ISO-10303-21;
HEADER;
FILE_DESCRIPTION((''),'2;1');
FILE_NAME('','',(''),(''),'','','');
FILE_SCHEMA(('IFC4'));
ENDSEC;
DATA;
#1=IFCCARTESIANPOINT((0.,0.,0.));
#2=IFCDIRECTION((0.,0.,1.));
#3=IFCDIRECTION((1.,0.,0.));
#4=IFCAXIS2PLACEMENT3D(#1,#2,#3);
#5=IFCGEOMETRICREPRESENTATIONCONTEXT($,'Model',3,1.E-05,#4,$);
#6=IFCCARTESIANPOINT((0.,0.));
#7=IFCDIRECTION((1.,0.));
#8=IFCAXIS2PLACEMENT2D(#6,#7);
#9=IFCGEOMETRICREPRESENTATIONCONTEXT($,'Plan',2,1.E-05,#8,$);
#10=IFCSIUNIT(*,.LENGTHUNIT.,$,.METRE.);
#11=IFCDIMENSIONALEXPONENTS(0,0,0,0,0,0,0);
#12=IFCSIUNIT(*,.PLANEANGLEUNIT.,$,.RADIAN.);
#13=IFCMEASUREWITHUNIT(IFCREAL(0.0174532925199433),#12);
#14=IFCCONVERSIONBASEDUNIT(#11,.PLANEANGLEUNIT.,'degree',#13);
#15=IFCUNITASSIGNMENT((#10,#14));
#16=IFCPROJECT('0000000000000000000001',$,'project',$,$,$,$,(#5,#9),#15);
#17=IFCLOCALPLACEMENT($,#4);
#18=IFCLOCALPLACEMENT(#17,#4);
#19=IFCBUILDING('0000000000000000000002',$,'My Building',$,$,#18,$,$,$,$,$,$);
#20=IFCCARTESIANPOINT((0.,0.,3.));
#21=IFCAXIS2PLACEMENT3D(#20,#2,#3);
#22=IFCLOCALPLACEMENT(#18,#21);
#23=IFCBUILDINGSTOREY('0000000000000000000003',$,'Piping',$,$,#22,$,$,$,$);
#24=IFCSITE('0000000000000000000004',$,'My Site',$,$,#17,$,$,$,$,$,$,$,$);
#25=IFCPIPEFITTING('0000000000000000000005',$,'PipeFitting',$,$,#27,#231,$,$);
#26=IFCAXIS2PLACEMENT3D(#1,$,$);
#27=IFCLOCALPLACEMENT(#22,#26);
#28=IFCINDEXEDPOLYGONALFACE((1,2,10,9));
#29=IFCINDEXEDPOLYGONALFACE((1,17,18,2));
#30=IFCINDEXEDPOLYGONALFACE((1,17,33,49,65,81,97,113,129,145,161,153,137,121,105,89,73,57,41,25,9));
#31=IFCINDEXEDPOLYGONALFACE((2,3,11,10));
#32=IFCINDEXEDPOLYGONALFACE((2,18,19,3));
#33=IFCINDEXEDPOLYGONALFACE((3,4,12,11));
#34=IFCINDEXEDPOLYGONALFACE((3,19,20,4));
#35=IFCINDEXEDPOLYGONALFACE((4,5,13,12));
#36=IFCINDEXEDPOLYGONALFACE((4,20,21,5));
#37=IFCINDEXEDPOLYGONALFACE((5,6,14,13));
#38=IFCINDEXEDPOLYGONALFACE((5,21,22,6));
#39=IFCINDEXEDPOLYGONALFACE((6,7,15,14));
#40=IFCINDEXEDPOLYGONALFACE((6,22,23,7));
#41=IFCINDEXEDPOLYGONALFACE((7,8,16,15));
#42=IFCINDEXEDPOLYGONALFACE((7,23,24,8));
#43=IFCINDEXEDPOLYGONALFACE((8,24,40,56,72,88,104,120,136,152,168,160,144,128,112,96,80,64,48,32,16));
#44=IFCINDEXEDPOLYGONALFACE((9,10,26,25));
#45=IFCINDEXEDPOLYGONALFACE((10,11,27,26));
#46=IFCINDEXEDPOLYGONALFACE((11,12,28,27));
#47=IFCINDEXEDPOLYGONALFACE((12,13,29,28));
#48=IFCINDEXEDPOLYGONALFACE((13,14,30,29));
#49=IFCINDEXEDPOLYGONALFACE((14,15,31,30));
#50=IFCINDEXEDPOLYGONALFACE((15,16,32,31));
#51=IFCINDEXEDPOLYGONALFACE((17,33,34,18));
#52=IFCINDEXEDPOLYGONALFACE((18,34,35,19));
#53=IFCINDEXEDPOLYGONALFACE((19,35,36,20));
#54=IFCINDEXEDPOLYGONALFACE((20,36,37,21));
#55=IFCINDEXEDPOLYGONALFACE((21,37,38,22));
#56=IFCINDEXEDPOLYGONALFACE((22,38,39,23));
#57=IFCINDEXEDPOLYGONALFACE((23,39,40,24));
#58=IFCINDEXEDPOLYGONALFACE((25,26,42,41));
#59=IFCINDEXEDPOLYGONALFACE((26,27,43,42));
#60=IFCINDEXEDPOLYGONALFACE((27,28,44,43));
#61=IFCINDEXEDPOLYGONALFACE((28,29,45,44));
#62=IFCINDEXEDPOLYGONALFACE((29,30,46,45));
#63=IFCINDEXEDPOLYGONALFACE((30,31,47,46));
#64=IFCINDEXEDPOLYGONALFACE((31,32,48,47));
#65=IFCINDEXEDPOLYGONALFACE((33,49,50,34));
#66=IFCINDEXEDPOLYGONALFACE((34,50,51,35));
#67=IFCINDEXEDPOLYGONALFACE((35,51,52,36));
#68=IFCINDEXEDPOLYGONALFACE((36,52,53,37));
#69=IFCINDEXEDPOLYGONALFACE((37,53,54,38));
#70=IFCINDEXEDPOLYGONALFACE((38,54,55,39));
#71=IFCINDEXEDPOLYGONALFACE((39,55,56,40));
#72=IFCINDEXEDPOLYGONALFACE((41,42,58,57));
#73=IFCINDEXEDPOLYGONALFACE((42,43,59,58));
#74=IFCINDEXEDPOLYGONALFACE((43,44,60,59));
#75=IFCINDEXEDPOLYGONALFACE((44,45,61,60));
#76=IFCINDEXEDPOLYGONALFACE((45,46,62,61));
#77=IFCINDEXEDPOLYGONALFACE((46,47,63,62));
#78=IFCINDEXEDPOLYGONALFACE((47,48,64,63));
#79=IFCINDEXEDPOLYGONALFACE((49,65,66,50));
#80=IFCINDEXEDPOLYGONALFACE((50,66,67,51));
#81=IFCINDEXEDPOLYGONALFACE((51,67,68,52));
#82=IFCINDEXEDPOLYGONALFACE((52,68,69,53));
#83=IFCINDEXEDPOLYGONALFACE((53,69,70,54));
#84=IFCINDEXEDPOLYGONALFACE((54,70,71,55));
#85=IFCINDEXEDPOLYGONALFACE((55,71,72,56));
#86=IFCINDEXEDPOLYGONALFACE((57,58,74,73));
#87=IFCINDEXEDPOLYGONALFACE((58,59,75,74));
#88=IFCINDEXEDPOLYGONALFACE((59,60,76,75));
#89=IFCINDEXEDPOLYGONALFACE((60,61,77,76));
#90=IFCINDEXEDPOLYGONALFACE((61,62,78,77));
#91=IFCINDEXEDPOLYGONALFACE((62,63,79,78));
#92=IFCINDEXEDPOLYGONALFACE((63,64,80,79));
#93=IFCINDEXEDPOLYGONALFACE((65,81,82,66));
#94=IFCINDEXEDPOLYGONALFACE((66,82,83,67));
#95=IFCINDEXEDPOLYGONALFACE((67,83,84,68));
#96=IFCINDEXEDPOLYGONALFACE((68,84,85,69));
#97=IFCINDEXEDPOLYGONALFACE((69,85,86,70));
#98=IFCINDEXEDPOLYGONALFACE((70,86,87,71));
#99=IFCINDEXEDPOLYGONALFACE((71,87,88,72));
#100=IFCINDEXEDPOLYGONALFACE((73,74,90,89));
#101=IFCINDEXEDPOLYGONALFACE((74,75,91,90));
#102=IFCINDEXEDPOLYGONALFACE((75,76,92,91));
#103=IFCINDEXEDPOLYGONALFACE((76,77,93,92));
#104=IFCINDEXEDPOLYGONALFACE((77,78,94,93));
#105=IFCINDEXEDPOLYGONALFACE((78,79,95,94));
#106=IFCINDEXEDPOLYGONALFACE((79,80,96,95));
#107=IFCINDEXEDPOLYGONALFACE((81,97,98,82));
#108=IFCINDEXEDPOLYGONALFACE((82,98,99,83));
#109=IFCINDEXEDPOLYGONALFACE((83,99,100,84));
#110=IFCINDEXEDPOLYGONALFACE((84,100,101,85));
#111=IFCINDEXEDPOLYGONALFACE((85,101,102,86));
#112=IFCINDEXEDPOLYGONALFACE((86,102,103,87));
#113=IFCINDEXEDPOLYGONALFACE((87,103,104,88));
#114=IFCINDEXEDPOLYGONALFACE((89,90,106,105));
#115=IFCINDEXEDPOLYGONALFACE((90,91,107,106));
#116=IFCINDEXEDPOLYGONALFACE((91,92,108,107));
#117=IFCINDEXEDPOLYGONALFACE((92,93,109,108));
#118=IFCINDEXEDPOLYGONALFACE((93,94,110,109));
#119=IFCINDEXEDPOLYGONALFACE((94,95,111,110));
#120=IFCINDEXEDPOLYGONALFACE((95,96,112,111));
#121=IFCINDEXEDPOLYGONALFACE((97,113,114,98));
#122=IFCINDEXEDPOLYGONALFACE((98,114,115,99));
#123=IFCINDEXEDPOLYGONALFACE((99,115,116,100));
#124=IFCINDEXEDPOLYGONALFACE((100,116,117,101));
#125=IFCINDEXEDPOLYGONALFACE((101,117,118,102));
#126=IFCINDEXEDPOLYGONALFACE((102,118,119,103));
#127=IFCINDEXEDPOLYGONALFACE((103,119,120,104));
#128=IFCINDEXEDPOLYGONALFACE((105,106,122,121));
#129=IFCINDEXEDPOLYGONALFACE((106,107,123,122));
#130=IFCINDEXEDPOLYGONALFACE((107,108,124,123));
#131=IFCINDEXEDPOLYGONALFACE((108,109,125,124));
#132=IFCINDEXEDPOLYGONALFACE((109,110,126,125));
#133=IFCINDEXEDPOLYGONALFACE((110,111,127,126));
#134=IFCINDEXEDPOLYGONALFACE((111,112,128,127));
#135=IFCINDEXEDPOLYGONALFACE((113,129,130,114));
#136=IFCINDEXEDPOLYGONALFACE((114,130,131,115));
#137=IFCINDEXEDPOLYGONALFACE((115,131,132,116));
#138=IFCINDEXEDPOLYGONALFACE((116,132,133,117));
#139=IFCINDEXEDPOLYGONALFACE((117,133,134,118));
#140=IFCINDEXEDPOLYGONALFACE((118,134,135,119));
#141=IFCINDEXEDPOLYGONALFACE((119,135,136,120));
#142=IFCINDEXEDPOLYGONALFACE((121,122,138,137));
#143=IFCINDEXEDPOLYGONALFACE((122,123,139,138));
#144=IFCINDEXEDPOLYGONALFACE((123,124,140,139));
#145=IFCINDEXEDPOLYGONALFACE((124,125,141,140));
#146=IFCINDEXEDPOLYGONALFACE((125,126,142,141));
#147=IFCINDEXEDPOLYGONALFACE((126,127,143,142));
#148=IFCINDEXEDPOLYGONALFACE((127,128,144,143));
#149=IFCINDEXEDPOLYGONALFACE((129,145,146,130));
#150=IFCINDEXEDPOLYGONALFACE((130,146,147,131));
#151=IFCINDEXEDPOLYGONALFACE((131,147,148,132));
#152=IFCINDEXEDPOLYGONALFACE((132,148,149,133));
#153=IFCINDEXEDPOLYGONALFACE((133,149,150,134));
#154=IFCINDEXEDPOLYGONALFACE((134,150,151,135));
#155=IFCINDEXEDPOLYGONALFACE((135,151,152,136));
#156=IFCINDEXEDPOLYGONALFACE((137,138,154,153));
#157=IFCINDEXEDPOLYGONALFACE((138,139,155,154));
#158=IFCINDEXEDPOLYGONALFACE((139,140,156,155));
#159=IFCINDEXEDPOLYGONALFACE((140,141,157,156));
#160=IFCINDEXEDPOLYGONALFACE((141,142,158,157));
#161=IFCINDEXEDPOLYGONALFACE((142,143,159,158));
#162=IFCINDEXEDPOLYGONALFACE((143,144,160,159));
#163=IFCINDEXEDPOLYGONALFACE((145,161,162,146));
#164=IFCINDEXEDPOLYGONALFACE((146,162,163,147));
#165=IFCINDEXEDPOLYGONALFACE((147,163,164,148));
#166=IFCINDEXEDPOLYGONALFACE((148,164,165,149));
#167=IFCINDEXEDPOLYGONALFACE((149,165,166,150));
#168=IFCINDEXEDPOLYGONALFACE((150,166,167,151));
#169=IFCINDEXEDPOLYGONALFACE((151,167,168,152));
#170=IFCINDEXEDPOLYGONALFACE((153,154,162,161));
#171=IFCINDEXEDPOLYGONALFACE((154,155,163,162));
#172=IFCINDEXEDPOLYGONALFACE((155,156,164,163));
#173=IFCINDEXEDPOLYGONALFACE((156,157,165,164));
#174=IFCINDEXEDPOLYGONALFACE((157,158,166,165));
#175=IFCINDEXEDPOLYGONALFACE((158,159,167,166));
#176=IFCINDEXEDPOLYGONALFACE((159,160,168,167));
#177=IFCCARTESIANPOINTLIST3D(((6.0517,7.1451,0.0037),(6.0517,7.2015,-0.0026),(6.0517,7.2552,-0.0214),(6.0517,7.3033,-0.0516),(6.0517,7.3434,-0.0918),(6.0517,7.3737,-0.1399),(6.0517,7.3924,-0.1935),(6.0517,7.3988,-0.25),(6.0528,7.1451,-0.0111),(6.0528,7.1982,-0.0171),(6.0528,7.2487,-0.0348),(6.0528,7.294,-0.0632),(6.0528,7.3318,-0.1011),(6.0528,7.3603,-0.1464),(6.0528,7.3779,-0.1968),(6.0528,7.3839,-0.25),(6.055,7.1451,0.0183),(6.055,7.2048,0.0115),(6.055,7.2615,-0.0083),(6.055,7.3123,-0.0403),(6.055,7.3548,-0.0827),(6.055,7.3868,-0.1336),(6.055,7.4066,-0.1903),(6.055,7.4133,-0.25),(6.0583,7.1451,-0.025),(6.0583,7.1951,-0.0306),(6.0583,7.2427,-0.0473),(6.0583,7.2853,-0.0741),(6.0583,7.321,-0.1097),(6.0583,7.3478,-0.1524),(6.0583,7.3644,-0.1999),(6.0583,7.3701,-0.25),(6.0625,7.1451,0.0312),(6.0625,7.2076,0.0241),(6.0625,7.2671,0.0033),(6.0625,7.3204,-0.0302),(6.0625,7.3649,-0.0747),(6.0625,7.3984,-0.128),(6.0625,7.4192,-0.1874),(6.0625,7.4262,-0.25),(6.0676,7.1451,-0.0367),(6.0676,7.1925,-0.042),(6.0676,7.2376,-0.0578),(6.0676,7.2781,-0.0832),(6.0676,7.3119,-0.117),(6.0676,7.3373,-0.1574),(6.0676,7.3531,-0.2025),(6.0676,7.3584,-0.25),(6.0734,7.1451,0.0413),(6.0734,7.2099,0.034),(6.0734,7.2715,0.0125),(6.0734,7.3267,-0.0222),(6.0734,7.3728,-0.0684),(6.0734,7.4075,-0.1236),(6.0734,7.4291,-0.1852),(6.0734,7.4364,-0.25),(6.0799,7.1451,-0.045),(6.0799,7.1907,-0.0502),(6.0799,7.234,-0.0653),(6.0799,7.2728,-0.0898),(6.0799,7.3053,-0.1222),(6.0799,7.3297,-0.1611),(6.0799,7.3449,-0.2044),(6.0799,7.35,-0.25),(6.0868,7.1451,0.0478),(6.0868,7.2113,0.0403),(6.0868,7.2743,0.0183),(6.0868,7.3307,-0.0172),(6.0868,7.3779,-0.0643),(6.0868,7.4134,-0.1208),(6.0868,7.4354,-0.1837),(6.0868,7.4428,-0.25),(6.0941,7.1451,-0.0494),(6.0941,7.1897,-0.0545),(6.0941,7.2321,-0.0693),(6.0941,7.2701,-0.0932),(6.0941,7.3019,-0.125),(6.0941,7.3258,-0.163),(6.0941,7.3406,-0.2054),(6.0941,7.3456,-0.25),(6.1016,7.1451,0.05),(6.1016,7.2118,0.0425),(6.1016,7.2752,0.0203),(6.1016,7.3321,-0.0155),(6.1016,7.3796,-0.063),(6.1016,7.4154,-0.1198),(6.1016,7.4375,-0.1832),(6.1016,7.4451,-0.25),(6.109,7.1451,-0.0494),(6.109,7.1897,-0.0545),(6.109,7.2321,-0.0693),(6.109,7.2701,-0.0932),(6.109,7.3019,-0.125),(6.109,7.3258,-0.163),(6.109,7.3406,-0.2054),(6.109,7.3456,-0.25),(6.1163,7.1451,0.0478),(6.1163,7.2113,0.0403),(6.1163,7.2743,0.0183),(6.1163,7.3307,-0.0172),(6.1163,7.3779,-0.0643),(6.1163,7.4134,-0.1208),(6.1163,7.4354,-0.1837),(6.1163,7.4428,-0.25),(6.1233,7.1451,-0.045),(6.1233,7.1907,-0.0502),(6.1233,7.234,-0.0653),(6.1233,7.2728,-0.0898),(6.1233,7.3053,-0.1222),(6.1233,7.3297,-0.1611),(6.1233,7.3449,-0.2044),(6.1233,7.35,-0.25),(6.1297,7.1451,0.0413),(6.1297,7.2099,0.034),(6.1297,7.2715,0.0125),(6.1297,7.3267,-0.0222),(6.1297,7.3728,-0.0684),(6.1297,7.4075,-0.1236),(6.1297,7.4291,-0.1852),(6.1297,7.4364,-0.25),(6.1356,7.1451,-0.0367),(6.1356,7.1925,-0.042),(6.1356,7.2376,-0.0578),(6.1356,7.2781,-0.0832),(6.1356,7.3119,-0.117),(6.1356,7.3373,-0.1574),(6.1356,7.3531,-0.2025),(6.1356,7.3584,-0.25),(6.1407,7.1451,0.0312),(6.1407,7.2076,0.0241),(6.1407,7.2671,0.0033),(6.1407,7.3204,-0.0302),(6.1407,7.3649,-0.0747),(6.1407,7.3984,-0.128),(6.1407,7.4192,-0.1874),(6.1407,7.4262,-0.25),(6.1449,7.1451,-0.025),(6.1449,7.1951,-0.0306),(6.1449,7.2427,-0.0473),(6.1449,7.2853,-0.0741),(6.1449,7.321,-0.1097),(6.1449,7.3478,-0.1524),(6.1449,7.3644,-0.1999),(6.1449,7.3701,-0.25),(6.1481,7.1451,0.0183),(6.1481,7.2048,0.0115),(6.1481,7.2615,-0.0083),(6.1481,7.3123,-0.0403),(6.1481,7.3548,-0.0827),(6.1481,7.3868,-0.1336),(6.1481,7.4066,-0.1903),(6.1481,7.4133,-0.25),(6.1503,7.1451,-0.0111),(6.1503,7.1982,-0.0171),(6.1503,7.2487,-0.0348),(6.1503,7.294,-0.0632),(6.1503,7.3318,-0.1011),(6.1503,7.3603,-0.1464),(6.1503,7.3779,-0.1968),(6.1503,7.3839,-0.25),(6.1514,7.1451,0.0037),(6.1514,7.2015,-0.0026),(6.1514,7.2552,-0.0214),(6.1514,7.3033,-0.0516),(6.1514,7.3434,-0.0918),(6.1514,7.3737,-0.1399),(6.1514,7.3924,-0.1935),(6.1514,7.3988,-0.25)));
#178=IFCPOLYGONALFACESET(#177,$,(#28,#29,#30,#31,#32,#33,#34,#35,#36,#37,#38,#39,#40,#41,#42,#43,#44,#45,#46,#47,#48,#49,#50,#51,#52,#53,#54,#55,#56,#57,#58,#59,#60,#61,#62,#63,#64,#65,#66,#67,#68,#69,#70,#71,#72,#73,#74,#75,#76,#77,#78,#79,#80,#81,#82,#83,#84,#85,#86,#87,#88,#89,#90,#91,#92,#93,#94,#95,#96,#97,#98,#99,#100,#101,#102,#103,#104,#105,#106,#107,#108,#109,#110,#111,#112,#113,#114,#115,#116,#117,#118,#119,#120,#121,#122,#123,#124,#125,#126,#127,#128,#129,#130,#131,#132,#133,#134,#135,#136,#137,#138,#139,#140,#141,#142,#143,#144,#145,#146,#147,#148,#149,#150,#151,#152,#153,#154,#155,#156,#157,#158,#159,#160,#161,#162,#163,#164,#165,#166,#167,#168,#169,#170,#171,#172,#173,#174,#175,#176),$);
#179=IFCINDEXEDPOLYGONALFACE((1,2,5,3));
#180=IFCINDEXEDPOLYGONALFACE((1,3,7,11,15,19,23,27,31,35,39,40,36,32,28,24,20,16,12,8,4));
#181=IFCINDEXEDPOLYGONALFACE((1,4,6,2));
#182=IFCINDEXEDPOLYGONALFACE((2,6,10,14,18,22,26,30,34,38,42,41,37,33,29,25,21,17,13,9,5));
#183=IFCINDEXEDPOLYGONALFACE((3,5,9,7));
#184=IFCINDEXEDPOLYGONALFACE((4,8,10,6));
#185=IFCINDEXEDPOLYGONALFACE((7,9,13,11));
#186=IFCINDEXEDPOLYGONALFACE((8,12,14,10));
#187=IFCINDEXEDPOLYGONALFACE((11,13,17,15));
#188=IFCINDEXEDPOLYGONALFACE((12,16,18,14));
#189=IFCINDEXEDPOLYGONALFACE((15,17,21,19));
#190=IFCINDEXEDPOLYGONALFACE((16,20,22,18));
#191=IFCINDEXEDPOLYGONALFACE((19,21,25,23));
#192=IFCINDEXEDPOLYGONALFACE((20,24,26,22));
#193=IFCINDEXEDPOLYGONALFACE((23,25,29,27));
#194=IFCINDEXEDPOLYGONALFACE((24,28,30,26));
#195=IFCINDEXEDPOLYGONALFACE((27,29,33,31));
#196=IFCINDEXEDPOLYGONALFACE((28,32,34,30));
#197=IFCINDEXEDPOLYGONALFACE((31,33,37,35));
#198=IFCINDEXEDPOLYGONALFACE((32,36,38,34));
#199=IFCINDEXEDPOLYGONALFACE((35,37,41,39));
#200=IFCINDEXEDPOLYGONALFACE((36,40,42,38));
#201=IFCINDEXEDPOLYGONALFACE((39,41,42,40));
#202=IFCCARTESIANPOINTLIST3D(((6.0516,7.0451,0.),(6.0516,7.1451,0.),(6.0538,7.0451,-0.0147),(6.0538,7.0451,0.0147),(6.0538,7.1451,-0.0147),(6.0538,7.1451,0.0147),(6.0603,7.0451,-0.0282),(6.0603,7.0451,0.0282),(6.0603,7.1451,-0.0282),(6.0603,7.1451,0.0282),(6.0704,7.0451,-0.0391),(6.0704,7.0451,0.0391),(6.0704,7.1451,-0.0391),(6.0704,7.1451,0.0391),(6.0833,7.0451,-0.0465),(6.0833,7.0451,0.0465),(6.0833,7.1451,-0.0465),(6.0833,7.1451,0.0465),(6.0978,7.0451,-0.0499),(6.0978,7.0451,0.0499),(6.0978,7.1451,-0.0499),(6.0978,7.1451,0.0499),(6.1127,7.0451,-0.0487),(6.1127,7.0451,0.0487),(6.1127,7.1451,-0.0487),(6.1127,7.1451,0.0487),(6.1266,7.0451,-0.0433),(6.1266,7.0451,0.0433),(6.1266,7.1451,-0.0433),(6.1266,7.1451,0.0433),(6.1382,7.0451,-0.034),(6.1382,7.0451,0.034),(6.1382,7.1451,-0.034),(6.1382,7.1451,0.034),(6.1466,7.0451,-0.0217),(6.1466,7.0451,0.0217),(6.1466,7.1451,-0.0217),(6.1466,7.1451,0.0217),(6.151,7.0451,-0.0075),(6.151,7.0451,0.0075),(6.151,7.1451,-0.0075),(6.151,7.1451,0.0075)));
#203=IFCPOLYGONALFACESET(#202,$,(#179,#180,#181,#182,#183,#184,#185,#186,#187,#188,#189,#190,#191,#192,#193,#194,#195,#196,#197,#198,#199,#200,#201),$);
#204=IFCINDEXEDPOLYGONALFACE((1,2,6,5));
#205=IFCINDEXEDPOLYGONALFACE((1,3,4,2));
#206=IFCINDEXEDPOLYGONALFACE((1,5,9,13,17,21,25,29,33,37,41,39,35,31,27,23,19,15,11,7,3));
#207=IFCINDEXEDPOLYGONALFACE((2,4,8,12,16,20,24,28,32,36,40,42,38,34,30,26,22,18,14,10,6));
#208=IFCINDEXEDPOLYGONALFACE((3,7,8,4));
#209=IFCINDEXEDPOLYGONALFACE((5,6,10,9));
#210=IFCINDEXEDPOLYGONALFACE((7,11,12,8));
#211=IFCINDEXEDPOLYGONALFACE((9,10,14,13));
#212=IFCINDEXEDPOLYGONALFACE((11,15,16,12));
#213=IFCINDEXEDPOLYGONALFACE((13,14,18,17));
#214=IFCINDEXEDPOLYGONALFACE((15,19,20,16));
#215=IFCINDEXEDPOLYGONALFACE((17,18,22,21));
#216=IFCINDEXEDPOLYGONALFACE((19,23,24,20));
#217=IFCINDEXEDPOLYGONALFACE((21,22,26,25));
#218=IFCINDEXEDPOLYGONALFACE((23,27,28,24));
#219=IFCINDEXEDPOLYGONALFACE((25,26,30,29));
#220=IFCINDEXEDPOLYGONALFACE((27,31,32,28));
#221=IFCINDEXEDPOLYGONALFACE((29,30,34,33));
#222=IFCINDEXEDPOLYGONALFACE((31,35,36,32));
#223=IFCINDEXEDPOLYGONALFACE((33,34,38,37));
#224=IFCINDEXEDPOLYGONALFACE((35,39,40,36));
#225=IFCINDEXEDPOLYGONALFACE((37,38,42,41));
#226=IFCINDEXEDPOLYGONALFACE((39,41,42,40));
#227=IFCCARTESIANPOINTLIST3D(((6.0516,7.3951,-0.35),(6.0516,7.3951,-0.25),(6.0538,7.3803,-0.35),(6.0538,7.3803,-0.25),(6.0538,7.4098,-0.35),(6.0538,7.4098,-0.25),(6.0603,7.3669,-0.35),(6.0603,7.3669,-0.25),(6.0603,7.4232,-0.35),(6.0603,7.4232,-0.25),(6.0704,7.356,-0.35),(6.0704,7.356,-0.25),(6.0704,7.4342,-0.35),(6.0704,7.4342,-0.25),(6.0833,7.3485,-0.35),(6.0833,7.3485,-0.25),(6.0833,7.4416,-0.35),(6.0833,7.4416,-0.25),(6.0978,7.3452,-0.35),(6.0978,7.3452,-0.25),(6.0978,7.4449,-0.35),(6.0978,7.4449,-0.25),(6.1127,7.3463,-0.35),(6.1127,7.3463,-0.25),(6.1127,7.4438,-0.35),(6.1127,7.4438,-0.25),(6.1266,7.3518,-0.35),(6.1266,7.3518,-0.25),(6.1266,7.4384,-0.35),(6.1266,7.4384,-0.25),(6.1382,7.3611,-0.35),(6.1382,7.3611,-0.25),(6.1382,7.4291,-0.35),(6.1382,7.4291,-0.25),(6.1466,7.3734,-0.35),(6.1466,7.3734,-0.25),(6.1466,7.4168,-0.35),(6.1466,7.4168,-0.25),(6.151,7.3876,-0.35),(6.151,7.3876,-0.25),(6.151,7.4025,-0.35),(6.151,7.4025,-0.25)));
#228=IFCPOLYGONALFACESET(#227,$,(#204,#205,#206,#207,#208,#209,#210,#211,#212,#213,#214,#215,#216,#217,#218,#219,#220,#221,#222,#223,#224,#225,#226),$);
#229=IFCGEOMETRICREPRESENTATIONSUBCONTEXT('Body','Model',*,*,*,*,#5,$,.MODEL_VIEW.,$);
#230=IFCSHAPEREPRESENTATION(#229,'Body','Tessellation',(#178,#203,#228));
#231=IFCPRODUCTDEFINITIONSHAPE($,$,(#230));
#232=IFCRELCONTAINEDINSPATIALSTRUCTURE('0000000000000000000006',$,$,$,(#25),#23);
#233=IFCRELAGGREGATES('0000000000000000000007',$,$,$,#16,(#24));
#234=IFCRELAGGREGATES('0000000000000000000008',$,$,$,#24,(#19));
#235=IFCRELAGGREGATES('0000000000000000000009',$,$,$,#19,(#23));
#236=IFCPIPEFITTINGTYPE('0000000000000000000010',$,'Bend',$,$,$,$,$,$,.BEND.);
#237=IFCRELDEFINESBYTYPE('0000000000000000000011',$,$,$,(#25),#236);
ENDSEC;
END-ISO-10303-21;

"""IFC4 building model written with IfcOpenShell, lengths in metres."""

from ifc_helpers import new_model, entity, si_unit, converted_unit, frame, origin_with_axes, origin_2d_with_axis, place, context, subcontext, project, spatial, circle, extrude, source, transform, mapped, type_object, type_shapes, element, save


model = new_model("IFC4")

# Units and contexts
model_context = context("Model", 3, precision=1e-05, world=origin_with_axes())
plan_context = context("Plan", 2, precision=1e-05, world=origin_2d_with_axis())
body_context = subcontext(model_context, "Body", "Model", "MODEL_VIEW")
ifc_project = project(units=[si_unit("LENGTHUNIT", "METRE"), converted_unit("PLANEANGLEUNIT", "degree", entity("IfcReal", 0.0174532925199433), si_unit("PLANEANGLEUNIT", "RADIAN"), dimensions=[0, 0, 0, 0, 0, 0, 0])], contexts=[model_context, plan_context])

# Site, building, storey
site_placement = place(None, origin_with_axes())
site = spatial("IfcSite", under=ifc_project, at=site_placement, Name="My Site")
building_placement = place(site_placement, origin_with_axes())
building = spatial("IfcBuilding", under=site, at=building_placement, Name="My Building")
storey_placement = place(building_placement, frame((0.0, 0.0, 3.0), z_axis=(0.0, 0.0, 1.0), x_axis=(1.0, 0.0, 0.0)))
storey = spatial("IfcBuildingStorey", under=building, at=storey_placement, Name="Piping")

# Pipe fitting
pipe_fitting_type = type_object("IfcPipeFittingType", Name="Bend", PredefinedType="BEND")
shared_shape = source(origin_with_axes(), body_context, "Body", "SolidModel", [
    entity("IfcSweptDiskSolid", entity("IfcIndexedPolyCurve", entity("IfcCartesianPointList3D", [[0.0, 0.0, -0.1], [0.0, 0.0732, -0.2768], [0.0, 0.25, -0.35]]), [entity("IfcArcIndex", [1, 2, 3])]), 0.05),
    extrude(circle(Radius=0.05), origin_with_axes(), (0.0, 0.0, -1.0), 0.1),
    extrude(circle(Radius=0.05), frame((0.0, 0.25, -0.35), z_axis=(0.0, 1.0, 0.0), x_axis=(1.0, 0.0, 0.0)), (0.0, 0.0, 1.0), 0.1),
])
type_shapes(pipe_fitting_type, [shared_shape])
for number, where, z_axis, x_axis, name in (
    (1, (6.1016, 7.0451, 0.0), (0.0, -1.0, 0.0), (-1.0, 0.0, 0.0), "PipeFitting"),
):
    element("IfcPipeFitting", number, at=place(storey_placement, frame(where, z_axis=z_axis, x_axis=x_axis)), inside=storey, type_object=pipe_fitting_type, Name=name, context=body_context, shape_type="MappedRepresentation", body=[
        mapped(shared_shape, transform((0.0, 0.0, 0.0), x_axis=(1.0, 0.0, 0.0), y_axis=(0.0, 1.0, 0.0), z_axis=(0.0, 0.0, 1.0), scale=1.0)),
    ])

save(model, "model.ifc")
